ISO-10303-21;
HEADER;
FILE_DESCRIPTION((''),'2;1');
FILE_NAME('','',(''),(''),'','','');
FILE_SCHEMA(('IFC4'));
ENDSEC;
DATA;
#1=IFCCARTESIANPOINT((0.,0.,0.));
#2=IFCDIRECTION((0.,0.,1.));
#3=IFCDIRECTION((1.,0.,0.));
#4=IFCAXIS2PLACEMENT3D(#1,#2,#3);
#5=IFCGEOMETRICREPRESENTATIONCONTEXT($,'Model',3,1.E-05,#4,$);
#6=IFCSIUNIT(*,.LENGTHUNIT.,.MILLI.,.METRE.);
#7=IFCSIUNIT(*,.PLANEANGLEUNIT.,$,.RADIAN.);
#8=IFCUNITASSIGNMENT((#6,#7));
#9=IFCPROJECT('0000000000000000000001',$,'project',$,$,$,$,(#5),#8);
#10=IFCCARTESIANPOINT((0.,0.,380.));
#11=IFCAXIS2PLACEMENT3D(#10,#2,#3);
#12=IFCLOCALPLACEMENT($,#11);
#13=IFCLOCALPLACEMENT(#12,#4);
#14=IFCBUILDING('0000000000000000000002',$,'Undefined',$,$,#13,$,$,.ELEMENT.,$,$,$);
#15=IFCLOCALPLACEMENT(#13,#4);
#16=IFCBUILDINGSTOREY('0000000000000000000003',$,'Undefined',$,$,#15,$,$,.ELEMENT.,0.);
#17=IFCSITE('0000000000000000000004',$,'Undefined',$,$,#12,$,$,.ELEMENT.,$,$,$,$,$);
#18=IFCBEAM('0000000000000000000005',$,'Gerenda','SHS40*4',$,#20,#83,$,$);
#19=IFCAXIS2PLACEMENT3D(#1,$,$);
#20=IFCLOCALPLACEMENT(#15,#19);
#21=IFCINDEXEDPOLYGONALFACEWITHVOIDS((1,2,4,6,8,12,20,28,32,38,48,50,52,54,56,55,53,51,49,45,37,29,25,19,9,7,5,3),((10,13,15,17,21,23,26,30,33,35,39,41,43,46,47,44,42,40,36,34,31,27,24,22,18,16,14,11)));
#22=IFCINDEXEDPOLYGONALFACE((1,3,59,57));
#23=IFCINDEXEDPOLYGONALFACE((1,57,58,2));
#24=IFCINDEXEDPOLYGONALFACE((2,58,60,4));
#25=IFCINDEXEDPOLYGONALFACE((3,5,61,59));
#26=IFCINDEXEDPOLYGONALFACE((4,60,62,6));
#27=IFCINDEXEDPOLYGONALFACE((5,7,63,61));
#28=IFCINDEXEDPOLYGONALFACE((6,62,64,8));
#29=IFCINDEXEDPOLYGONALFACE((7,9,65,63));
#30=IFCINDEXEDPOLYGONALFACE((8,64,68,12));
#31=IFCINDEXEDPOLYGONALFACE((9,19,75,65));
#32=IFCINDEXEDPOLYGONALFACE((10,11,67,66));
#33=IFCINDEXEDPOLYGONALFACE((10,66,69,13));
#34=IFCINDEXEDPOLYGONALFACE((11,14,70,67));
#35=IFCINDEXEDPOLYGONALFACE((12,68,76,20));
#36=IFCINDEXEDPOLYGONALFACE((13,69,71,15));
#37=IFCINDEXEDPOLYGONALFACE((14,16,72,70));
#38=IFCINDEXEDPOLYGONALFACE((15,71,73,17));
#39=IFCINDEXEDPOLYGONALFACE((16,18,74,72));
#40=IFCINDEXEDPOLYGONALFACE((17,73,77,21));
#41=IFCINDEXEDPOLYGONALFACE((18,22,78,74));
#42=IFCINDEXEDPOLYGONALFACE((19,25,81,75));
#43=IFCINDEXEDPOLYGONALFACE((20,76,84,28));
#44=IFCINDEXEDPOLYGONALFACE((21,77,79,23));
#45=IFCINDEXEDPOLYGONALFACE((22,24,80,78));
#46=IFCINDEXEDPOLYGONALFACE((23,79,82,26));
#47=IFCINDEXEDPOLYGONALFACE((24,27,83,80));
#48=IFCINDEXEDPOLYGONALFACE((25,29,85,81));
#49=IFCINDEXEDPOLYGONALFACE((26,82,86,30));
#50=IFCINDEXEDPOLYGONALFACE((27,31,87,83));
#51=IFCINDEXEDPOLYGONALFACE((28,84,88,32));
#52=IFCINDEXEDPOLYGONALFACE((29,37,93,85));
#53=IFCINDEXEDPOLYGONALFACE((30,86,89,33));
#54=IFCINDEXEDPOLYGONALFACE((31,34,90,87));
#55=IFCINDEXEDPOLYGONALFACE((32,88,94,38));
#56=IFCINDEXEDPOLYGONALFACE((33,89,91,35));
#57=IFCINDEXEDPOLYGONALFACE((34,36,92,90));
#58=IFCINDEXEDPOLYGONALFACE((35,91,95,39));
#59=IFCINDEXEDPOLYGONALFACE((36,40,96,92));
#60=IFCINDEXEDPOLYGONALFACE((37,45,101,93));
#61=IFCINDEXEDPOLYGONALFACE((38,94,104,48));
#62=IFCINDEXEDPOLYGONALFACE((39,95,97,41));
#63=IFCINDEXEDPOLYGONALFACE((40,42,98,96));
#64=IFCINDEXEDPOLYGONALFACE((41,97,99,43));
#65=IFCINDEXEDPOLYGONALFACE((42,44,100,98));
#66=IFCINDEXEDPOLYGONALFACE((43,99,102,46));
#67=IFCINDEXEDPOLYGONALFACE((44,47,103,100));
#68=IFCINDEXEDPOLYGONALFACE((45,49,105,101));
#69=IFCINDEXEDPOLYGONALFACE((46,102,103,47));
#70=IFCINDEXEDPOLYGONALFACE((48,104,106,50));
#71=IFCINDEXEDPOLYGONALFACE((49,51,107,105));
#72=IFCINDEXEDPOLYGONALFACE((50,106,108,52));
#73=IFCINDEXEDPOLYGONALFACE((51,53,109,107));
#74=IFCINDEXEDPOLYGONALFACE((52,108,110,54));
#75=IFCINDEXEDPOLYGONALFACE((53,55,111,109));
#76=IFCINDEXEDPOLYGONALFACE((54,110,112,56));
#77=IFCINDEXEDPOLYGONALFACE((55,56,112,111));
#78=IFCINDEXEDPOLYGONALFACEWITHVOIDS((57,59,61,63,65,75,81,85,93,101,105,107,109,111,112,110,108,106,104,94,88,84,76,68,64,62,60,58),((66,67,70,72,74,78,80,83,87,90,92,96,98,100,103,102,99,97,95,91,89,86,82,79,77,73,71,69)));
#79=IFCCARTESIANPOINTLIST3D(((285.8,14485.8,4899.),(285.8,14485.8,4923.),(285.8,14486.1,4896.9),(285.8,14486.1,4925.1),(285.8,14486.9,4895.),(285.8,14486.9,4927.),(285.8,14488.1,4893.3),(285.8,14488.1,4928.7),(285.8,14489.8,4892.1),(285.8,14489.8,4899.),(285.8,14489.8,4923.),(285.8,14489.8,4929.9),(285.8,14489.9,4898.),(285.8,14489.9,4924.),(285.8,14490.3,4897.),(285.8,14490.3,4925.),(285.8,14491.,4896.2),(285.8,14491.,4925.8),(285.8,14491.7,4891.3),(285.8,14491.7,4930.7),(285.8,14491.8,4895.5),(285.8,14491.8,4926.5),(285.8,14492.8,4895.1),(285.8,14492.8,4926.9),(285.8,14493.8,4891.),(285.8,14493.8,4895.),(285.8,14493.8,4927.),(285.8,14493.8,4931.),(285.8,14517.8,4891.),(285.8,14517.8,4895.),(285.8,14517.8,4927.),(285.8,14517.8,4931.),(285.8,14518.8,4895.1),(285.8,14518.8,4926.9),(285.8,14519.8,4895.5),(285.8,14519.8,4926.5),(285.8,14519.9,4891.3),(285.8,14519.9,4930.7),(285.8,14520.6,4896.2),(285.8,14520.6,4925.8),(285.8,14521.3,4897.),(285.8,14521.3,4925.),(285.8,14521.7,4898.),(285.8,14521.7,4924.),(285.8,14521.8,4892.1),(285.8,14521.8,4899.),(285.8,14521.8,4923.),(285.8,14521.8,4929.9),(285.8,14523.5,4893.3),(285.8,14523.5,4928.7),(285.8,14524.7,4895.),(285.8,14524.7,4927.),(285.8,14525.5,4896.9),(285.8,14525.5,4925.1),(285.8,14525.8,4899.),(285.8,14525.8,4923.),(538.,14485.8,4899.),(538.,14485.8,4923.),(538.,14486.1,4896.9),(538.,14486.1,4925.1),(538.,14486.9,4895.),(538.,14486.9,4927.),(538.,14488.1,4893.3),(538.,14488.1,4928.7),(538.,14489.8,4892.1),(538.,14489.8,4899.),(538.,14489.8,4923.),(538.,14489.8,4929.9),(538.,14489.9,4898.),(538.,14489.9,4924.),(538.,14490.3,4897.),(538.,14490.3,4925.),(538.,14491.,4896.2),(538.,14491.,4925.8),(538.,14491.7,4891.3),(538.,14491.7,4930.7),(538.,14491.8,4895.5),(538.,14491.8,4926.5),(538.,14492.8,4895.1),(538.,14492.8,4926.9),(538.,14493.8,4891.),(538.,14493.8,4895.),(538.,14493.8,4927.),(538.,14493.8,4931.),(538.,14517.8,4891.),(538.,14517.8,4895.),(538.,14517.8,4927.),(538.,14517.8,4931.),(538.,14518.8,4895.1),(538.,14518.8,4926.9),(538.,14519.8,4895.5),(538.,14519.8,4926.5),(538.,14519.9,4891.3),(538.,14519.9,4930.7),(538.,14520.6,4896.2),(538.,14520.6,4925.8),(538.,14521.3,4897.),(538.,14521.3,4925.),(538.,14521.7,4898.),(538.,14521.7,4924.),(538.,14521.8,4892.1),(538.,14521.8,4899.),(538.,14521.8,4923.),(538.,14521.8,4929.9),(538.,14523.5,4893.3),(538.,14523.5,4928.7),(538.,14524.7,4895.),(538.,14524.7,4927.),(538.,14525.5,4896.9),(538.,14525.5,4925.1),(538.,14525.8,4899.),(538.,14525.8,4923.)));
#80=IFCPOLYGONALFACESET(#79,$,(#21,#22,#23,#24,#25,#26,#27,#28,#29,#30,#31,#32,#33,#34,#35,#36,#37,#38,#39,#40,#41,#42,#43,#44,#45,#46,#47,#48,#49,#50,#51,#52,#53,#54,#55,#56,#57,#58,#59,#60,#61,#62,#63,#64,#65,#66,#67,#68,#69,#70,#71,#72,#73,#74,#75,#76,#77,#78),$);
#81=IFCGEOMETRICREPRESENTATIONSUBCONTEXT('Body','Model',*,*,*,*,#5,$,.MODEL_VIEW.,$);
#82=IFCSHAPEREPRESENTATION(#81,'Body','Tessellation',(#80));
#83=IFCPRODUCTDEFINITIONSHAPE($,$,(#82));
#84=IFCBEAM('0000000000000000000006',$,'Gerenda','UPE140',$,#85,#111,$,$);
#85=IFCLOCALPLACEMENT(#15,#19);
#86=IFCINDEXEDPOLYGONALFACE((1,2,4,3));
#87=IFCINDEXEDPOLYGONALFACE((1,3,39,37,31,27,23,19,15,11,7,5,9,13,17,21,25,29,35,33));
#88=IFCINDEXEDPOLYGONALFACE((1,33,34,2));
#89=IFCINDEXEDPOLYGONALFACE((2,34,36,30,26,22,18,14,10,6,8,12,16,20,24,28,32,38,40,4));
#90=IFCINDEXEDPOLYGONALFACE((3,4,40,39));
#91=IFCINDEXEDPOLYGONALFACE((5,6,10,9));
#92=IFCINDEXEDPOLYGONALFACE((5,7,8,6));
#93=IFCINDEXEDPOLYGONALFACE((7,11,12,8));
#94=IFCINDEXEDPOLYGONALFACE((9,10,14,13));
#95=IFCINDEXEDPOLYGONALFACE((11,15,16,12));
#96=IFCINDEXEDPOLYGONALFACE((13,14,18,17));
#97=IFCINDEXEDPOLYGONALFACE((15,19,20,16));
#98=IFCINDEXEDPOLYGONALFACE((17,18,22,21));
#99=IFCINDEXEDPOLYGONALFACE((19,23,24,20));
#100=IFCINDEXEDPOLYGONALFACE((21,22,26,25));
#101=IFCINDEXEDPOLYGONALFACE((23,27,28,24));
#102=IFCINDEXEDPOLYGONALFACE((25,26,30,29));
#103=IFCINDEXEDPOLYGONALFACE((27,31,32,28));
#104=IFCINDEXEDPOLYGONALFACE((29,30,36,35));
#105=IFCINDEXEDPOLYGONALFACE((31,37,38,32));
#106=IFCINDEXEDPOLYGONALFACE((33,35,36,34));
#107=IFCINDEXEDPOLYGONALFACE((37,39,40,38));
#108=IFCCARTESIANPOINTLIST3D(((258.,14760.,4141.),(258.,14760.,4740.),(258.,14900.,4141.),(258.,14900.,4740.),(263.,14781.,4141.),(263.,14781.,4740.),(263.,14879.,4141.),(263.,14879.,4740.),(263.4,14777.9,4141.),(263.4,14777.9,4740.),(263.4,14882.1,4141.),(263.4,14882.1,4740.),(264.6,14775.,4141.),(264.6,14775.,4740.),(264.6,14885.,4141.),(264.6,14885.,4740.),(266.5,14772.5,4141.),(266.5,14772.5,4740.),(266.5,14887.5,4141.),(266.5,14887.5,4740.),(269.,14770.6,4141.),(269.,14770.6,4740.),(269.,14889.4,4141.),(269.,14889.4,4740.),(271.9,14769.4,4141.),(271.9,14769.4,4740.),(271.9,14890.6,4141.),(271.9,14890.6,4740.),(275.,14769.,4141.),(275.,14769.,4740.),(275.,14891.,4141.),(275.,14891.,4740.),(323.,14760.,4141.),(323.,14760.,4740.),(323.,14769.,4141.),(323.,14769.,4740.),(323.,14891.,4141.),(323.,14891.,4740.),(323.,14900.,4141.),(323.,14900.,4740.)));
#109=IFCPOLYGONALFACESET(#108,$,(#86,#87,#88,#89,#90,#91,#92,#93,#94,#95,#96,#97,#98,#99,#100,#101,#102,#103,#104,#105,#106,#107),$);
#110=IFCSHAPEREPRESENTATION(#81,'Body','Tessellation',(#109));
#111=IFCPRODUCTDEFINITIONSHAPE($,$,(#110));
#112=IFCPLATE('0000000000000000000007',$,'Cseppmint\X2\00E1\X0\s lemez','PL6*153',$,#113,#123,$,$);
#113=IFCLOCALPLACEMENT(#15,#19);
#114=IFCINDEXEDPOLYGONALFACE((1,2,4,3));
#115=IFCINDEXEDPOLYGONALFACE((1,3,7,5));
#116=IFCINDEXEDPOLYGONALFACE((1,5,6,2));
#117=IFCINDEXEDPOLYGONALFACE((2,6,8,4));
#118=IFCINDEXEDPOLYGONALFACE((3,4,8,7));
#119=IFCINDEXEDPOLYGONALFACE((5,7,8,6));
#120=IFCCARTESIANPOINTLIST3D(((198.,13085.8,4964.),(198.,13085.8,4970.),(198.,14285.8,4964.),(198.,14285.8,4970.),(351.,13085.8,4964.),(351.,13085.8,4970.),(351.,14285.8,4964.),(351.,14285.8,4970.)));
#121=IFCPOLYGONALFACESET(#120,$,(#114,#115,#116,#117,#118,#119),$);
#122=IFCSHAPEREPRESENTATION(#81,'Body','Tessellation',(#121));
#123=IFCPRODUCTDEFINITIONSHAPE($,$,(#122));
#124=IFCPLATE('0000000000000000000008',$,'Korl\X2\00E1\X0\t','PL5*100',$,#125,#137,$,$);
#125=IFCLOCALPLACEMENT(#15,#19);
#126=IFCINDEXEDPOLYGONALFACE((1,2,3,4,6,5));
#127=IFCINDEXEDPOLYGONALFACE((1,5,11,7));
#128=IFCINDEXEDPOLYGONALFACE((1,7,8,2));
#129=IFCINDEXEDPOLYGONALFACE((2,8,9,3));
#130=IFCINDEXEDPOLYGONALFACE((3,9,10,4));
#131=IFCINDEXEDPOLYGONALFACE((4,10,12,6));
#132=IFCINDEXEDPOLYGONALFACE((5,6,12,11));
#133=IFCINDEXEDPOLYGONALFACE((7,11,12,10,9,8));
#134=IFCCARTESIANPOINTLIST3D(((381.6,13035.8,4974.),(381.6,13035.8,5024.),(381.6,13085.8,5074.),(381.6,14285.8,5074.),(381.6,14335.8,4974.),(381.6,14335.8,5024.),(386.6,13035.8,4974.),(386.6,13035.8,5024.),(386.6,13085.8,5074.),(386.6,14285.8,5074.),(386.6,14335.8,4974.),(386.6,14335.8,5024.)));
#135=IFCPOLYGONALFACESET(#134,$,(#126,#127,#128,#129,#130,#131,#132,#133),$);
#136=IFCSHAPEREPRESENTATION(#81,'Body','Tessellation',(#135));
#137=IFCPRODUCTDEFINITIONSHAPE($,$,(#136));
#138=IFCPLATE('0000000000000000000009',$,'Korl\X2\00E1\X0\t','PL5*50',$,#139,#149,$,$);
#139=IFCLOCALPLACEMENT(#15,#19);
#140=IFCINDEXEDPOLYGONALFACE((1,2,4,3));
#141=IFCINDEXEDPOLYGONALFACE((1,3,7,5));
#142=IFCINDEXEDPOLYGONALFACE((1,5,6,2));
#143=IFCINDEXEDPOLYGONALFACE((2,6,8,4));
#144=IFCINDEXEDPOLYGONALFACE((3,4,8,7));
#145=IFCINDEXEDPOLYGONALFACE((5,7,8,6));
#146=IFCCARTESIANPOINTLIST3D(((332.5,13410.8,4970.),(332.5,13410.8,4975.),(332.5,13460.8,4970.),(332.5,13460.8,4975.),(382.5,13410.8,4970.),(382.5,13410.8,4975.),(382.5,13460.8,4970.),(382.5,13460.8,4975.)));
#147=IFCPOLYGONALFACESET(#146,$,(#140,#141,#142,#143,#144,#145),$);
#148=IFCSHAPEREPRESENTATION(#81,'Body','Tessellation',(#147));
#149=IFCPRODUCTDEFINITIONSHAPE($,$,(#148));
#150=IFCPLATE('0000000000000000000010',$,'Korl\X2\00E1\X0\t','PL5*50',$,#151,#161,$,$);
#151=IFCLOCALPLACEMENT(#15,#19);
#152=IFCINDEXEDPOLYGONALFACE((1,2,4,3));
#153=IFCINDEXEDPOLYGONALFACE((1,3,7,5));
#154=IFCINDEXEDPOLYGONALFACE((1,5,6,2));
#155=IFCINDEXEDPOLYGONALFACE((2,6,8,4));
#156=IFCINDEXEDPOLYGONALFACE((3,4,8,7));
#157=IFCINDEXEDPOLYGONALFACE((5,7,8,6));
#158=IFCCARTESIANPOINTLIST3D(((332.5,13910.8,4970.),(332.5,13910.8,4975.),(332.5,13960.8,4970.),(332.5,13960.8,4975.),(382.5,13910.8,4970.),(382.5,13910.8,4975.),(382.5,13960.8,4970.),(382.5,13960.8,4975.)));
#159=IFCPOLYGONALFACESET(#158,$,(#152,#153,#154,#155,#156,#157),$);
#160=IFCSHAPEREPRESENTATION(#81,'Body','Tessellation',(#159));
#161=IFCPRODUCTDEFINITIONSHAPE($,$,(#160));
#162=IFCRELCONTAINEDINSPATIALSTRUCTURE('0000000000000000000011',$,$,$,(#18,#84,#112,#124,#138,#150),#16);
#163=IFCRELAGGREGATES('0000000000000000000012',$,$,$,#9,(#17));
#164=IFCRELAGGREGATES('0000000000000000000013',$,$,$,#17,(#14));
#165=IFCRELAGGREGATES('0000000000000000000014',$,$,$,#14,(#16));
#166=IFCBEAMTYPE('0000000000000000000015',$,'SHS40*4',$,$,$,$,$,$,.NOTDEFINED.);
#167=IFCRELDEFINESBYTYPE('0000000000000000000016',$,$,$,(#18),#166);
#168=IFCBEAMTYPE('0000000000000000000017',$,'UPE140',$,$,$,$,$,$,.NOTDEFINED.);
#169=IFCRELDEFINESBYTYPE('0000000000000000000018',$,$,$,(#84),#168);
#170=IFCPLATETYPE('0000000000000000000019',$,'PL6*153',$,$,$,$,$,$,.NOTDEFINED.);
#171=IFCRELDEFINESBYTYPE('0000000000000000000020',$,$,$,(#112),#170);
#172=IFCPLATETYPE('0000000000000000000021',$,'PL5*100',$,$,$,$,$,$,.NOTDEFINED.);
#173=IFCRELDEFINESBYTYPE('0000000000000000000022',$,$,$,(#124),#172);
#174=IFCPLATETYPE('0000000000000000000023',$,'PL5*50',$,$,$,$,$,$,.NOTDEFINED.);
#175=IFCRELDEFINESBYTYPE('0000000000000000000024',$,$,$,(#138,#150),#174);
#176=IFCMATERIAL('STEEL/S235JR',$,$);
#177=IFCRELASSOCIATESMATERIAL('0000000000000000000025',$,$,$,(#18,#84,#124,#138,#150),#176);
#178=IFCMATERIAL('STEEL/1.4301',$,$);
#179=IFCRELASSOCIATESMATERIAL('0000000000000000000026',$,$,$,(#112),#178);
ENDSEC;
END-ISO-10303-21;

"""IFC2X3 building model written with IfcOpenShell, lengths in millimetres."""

from ifc_helpers import new_model, si_unit, frame, origin_with_axes, origin_2d_with_axis, place, context, subcontext, project, spatial, polyline, hollow_rectangle, u_section, outline, extrude, clip, halfspace, material, type_object, element, save


model = new_model("IFC2X3")

# Units and contexts
model_context = context("Model", 3, precision=1e-05, world=origin_with_axes())
body_context = subcontext(model_context, "Body", "Model", "MODEL_VIEW")
ifc_project = project(units=[si_unit("LENGTHUNIT", "METRE", prefix="MILLI"), si_unit("PLANEANGLEUNIT", "RADIAN")], contexts=[model_context])

# Site, building, storey
site_placement = place(None, frame((0.0, 0.0, 380.0), z_axis=(0.0, 0.0, 1.0), x_axis=(1.0, 0.0, 0.0)))
site = spatial("IfcSite", under=ifc_project, at=site_placement, Name="Undefined", CompositionType="ELEMENT")
building_placement = place(site_placement, origin_with_axes())
building = spatial("IfcBuilding", under=site, at=building_placement, Name="Undefined", CompositionType="ELEMENT")
storey_placement = place(building_placement, origin_with_axes())
storey = spatial("IfcBuildingStorey", under=building, at=storey_placement, Name="Undefined", CompositionType="ELEMENT", Elevation=0.0)

# Shared definitions
ifc_material_1 = material(Name="STEEL/S235JR")

# Beams
beam_type_1 = type_object("IfcBeamType", Name="SHS40*4", PredefinedType="NOTDEFINED")
for number, where, z_axis, x_axis, name in (
    (1, (285.8, 14505.8, 4911.0), (0.0, 1.0, 0.0), (1.0, 0.0, 0.0), "Gerenda"),
):
    element("IfcBeam", number, at=place(storey_placement, frame(where, z_axis=z_axis, x_axis=x_axis)), inside=storey, type_object=beam_type_1, material=ifc_material_1, Name=name, Description="SHS40*4", context=body_context, shape_type="Clipping", body=[
        clip(extrude(hollow_rectangle(XDim=40.0, YDim=40.0, WallThickness=4.0, InnerFilletRadius=4.0, OuterFilletRadius=8.0, at=origin_2d_with_axis()), frame((252.2, 0.0, 0.0), z_axis=(-1.0, 0.0, 0.0), x_axis=(0.0, -1.0, 0.0)), (0.0, 0.0, 1.0), 252.2), halfspace(frame((0.0, 0.0, -20.0), z_axis=(1.0, 0.0, 0.0), x_axis=(0.0, -1.0, 0.0)), True)),
    ])
beam_type_2 = type_object("IfcBeamType", Name="UPE140", PredefinedType="NOTDEFINED")
beam_1_placement = place(storey_placement, frame((290.5, 14830.0, 4740.0), z_axis=(0.0, 1.0, 0.0), x_axis=(0.0, 0.0, -1.0)))
element("IfcBeam", 2, at=beam_1_placement, inside=storey, type_object=beam_type_2, material=ifc_material_1, Name="Gerenda", Description="UPE140", context=body_context, shape_type="Clipping", body=[
    clip(extrude(u_section(Depth=140.0, FlangeWidth=65.0, WebThickness=5.0, FlangeThickness=9.0, FilletRadius=12.0, at=origin_2d_with_axis()), frame((607.0, 0.0, 0.0), z_axis=(-1.0, 0.0, 0.0), x_axis=(0.0, -1.0, 0.0)), (0.0, 0.0, 1.0), 607.0), halfspace(frame((599.0, 0.0, -1000.0), z_axis=(-1.0, 0.0, 0.0), x_axis=(0.0, 1.0, 0.0)), True)),
])

# Plates
ifc_material_2 = material(Name="STEEL/1.4301")
plate_type_1 = type_object("IfcPlateType", Name="PL6*153", PredefinedType="NOTDEFINED")
plate_1_placement = place(storey_placement, frame((351.0, 14285.8, 4967.0), z_axis=(0.0, 0.0, 1.0), x_axis=(-1.0, 0.0, 0.0)))
element("IfcPlate", 3, at=plate_1_placement, inside=storey, type_object=plate_type_1, material=ifc_material_2, Name="Cseppmintás lemez", Description="PL6*153", context=body_context, shape_type="SweptSolid", body=[
    extrude(outline(polyline([(0.0, 0.0), (153.0, 0.0), (153.0, 1200.0), (0.0, 1200.0), (0.0, 0.0)])), frame((0.0, 0.0, -3.0), z_axis=(0.0, 0.0, 1.0), x_axis=(1.0, 0.0, 0.0)), (0.0, 0.0, 1.0), 6.0),
])
plate_type_2 = type_object("IfcPlateType", Name="PL5*100", PredefinedType="NOTDEFINED")
plate_2_placement = place(storey_placement, frame((384.1, 14335.8, 4974.0), z_axis=(-1.0, 0.0, 0.0), x_axis=(0.0, -1.0, 0.0)))
element("IfcPlate", 4, at=plate_2_placement, inside=storey, type_object=plate_type_2, material=ifc_material_1, Name="Korlát", Description="PL5*100", context=body_context, shape_type="SweptSolid", body=[
    extrude(outline(polyline([(0.0, 0.0), (1300.0, 0.0), (1300.0, 50.0), (1250.0, 100.0), (50.0, 100.0), (0.0, 50.0), (0.0, 0.0)])), frame((0.0, 0.0, -2.5), z_axis=(0.0, 0.0, 1.0), x_axis=(1.0, 0.0, 0.0)), (0.0, 0.0, 1.0), 5.0),
])
plate_type_3 = type_object("IfcPlateType", Name="PL5*50", PredefinedType="NOTDEFINED")
for number, where, z_axis, x_axis, name in (
    (5, (382.5, 13460.8, 4972.5), (0.0, 0.0, -1.0), (0.0, -1.0, 0.0), "Korlát"),
    (6, (382.5, 13960.8, 4972.5), (0.0, 0.0, -1.0), (0.0, -1.0, 0.0), "Korlát"),
):
    element("IfcPlate", number, at=place(storey_placement, frame(where, z_axis=z_axis, x_axis=x_axis)), inside=storey, type_object=plate_type_3, material=ifc_material_1, Name=name, Description="PL5*50", context=body_context, shape_type="SweptSolid", body=[
        extrude(outline(polyline([(0.0, 0.0), (50.0, 0.0), (50.0, 50.0), (0.0, 50.0), (0.0, 0.0)])), frame((0.0, 0.0, -2.5), z_axis=(0.0, 0.0, 1.0), x_axis=(1.0, 0.0, 0.0)), (0.0, 0.0, 1.0), 5.0),
    ])

save(model, "model.ifc")
